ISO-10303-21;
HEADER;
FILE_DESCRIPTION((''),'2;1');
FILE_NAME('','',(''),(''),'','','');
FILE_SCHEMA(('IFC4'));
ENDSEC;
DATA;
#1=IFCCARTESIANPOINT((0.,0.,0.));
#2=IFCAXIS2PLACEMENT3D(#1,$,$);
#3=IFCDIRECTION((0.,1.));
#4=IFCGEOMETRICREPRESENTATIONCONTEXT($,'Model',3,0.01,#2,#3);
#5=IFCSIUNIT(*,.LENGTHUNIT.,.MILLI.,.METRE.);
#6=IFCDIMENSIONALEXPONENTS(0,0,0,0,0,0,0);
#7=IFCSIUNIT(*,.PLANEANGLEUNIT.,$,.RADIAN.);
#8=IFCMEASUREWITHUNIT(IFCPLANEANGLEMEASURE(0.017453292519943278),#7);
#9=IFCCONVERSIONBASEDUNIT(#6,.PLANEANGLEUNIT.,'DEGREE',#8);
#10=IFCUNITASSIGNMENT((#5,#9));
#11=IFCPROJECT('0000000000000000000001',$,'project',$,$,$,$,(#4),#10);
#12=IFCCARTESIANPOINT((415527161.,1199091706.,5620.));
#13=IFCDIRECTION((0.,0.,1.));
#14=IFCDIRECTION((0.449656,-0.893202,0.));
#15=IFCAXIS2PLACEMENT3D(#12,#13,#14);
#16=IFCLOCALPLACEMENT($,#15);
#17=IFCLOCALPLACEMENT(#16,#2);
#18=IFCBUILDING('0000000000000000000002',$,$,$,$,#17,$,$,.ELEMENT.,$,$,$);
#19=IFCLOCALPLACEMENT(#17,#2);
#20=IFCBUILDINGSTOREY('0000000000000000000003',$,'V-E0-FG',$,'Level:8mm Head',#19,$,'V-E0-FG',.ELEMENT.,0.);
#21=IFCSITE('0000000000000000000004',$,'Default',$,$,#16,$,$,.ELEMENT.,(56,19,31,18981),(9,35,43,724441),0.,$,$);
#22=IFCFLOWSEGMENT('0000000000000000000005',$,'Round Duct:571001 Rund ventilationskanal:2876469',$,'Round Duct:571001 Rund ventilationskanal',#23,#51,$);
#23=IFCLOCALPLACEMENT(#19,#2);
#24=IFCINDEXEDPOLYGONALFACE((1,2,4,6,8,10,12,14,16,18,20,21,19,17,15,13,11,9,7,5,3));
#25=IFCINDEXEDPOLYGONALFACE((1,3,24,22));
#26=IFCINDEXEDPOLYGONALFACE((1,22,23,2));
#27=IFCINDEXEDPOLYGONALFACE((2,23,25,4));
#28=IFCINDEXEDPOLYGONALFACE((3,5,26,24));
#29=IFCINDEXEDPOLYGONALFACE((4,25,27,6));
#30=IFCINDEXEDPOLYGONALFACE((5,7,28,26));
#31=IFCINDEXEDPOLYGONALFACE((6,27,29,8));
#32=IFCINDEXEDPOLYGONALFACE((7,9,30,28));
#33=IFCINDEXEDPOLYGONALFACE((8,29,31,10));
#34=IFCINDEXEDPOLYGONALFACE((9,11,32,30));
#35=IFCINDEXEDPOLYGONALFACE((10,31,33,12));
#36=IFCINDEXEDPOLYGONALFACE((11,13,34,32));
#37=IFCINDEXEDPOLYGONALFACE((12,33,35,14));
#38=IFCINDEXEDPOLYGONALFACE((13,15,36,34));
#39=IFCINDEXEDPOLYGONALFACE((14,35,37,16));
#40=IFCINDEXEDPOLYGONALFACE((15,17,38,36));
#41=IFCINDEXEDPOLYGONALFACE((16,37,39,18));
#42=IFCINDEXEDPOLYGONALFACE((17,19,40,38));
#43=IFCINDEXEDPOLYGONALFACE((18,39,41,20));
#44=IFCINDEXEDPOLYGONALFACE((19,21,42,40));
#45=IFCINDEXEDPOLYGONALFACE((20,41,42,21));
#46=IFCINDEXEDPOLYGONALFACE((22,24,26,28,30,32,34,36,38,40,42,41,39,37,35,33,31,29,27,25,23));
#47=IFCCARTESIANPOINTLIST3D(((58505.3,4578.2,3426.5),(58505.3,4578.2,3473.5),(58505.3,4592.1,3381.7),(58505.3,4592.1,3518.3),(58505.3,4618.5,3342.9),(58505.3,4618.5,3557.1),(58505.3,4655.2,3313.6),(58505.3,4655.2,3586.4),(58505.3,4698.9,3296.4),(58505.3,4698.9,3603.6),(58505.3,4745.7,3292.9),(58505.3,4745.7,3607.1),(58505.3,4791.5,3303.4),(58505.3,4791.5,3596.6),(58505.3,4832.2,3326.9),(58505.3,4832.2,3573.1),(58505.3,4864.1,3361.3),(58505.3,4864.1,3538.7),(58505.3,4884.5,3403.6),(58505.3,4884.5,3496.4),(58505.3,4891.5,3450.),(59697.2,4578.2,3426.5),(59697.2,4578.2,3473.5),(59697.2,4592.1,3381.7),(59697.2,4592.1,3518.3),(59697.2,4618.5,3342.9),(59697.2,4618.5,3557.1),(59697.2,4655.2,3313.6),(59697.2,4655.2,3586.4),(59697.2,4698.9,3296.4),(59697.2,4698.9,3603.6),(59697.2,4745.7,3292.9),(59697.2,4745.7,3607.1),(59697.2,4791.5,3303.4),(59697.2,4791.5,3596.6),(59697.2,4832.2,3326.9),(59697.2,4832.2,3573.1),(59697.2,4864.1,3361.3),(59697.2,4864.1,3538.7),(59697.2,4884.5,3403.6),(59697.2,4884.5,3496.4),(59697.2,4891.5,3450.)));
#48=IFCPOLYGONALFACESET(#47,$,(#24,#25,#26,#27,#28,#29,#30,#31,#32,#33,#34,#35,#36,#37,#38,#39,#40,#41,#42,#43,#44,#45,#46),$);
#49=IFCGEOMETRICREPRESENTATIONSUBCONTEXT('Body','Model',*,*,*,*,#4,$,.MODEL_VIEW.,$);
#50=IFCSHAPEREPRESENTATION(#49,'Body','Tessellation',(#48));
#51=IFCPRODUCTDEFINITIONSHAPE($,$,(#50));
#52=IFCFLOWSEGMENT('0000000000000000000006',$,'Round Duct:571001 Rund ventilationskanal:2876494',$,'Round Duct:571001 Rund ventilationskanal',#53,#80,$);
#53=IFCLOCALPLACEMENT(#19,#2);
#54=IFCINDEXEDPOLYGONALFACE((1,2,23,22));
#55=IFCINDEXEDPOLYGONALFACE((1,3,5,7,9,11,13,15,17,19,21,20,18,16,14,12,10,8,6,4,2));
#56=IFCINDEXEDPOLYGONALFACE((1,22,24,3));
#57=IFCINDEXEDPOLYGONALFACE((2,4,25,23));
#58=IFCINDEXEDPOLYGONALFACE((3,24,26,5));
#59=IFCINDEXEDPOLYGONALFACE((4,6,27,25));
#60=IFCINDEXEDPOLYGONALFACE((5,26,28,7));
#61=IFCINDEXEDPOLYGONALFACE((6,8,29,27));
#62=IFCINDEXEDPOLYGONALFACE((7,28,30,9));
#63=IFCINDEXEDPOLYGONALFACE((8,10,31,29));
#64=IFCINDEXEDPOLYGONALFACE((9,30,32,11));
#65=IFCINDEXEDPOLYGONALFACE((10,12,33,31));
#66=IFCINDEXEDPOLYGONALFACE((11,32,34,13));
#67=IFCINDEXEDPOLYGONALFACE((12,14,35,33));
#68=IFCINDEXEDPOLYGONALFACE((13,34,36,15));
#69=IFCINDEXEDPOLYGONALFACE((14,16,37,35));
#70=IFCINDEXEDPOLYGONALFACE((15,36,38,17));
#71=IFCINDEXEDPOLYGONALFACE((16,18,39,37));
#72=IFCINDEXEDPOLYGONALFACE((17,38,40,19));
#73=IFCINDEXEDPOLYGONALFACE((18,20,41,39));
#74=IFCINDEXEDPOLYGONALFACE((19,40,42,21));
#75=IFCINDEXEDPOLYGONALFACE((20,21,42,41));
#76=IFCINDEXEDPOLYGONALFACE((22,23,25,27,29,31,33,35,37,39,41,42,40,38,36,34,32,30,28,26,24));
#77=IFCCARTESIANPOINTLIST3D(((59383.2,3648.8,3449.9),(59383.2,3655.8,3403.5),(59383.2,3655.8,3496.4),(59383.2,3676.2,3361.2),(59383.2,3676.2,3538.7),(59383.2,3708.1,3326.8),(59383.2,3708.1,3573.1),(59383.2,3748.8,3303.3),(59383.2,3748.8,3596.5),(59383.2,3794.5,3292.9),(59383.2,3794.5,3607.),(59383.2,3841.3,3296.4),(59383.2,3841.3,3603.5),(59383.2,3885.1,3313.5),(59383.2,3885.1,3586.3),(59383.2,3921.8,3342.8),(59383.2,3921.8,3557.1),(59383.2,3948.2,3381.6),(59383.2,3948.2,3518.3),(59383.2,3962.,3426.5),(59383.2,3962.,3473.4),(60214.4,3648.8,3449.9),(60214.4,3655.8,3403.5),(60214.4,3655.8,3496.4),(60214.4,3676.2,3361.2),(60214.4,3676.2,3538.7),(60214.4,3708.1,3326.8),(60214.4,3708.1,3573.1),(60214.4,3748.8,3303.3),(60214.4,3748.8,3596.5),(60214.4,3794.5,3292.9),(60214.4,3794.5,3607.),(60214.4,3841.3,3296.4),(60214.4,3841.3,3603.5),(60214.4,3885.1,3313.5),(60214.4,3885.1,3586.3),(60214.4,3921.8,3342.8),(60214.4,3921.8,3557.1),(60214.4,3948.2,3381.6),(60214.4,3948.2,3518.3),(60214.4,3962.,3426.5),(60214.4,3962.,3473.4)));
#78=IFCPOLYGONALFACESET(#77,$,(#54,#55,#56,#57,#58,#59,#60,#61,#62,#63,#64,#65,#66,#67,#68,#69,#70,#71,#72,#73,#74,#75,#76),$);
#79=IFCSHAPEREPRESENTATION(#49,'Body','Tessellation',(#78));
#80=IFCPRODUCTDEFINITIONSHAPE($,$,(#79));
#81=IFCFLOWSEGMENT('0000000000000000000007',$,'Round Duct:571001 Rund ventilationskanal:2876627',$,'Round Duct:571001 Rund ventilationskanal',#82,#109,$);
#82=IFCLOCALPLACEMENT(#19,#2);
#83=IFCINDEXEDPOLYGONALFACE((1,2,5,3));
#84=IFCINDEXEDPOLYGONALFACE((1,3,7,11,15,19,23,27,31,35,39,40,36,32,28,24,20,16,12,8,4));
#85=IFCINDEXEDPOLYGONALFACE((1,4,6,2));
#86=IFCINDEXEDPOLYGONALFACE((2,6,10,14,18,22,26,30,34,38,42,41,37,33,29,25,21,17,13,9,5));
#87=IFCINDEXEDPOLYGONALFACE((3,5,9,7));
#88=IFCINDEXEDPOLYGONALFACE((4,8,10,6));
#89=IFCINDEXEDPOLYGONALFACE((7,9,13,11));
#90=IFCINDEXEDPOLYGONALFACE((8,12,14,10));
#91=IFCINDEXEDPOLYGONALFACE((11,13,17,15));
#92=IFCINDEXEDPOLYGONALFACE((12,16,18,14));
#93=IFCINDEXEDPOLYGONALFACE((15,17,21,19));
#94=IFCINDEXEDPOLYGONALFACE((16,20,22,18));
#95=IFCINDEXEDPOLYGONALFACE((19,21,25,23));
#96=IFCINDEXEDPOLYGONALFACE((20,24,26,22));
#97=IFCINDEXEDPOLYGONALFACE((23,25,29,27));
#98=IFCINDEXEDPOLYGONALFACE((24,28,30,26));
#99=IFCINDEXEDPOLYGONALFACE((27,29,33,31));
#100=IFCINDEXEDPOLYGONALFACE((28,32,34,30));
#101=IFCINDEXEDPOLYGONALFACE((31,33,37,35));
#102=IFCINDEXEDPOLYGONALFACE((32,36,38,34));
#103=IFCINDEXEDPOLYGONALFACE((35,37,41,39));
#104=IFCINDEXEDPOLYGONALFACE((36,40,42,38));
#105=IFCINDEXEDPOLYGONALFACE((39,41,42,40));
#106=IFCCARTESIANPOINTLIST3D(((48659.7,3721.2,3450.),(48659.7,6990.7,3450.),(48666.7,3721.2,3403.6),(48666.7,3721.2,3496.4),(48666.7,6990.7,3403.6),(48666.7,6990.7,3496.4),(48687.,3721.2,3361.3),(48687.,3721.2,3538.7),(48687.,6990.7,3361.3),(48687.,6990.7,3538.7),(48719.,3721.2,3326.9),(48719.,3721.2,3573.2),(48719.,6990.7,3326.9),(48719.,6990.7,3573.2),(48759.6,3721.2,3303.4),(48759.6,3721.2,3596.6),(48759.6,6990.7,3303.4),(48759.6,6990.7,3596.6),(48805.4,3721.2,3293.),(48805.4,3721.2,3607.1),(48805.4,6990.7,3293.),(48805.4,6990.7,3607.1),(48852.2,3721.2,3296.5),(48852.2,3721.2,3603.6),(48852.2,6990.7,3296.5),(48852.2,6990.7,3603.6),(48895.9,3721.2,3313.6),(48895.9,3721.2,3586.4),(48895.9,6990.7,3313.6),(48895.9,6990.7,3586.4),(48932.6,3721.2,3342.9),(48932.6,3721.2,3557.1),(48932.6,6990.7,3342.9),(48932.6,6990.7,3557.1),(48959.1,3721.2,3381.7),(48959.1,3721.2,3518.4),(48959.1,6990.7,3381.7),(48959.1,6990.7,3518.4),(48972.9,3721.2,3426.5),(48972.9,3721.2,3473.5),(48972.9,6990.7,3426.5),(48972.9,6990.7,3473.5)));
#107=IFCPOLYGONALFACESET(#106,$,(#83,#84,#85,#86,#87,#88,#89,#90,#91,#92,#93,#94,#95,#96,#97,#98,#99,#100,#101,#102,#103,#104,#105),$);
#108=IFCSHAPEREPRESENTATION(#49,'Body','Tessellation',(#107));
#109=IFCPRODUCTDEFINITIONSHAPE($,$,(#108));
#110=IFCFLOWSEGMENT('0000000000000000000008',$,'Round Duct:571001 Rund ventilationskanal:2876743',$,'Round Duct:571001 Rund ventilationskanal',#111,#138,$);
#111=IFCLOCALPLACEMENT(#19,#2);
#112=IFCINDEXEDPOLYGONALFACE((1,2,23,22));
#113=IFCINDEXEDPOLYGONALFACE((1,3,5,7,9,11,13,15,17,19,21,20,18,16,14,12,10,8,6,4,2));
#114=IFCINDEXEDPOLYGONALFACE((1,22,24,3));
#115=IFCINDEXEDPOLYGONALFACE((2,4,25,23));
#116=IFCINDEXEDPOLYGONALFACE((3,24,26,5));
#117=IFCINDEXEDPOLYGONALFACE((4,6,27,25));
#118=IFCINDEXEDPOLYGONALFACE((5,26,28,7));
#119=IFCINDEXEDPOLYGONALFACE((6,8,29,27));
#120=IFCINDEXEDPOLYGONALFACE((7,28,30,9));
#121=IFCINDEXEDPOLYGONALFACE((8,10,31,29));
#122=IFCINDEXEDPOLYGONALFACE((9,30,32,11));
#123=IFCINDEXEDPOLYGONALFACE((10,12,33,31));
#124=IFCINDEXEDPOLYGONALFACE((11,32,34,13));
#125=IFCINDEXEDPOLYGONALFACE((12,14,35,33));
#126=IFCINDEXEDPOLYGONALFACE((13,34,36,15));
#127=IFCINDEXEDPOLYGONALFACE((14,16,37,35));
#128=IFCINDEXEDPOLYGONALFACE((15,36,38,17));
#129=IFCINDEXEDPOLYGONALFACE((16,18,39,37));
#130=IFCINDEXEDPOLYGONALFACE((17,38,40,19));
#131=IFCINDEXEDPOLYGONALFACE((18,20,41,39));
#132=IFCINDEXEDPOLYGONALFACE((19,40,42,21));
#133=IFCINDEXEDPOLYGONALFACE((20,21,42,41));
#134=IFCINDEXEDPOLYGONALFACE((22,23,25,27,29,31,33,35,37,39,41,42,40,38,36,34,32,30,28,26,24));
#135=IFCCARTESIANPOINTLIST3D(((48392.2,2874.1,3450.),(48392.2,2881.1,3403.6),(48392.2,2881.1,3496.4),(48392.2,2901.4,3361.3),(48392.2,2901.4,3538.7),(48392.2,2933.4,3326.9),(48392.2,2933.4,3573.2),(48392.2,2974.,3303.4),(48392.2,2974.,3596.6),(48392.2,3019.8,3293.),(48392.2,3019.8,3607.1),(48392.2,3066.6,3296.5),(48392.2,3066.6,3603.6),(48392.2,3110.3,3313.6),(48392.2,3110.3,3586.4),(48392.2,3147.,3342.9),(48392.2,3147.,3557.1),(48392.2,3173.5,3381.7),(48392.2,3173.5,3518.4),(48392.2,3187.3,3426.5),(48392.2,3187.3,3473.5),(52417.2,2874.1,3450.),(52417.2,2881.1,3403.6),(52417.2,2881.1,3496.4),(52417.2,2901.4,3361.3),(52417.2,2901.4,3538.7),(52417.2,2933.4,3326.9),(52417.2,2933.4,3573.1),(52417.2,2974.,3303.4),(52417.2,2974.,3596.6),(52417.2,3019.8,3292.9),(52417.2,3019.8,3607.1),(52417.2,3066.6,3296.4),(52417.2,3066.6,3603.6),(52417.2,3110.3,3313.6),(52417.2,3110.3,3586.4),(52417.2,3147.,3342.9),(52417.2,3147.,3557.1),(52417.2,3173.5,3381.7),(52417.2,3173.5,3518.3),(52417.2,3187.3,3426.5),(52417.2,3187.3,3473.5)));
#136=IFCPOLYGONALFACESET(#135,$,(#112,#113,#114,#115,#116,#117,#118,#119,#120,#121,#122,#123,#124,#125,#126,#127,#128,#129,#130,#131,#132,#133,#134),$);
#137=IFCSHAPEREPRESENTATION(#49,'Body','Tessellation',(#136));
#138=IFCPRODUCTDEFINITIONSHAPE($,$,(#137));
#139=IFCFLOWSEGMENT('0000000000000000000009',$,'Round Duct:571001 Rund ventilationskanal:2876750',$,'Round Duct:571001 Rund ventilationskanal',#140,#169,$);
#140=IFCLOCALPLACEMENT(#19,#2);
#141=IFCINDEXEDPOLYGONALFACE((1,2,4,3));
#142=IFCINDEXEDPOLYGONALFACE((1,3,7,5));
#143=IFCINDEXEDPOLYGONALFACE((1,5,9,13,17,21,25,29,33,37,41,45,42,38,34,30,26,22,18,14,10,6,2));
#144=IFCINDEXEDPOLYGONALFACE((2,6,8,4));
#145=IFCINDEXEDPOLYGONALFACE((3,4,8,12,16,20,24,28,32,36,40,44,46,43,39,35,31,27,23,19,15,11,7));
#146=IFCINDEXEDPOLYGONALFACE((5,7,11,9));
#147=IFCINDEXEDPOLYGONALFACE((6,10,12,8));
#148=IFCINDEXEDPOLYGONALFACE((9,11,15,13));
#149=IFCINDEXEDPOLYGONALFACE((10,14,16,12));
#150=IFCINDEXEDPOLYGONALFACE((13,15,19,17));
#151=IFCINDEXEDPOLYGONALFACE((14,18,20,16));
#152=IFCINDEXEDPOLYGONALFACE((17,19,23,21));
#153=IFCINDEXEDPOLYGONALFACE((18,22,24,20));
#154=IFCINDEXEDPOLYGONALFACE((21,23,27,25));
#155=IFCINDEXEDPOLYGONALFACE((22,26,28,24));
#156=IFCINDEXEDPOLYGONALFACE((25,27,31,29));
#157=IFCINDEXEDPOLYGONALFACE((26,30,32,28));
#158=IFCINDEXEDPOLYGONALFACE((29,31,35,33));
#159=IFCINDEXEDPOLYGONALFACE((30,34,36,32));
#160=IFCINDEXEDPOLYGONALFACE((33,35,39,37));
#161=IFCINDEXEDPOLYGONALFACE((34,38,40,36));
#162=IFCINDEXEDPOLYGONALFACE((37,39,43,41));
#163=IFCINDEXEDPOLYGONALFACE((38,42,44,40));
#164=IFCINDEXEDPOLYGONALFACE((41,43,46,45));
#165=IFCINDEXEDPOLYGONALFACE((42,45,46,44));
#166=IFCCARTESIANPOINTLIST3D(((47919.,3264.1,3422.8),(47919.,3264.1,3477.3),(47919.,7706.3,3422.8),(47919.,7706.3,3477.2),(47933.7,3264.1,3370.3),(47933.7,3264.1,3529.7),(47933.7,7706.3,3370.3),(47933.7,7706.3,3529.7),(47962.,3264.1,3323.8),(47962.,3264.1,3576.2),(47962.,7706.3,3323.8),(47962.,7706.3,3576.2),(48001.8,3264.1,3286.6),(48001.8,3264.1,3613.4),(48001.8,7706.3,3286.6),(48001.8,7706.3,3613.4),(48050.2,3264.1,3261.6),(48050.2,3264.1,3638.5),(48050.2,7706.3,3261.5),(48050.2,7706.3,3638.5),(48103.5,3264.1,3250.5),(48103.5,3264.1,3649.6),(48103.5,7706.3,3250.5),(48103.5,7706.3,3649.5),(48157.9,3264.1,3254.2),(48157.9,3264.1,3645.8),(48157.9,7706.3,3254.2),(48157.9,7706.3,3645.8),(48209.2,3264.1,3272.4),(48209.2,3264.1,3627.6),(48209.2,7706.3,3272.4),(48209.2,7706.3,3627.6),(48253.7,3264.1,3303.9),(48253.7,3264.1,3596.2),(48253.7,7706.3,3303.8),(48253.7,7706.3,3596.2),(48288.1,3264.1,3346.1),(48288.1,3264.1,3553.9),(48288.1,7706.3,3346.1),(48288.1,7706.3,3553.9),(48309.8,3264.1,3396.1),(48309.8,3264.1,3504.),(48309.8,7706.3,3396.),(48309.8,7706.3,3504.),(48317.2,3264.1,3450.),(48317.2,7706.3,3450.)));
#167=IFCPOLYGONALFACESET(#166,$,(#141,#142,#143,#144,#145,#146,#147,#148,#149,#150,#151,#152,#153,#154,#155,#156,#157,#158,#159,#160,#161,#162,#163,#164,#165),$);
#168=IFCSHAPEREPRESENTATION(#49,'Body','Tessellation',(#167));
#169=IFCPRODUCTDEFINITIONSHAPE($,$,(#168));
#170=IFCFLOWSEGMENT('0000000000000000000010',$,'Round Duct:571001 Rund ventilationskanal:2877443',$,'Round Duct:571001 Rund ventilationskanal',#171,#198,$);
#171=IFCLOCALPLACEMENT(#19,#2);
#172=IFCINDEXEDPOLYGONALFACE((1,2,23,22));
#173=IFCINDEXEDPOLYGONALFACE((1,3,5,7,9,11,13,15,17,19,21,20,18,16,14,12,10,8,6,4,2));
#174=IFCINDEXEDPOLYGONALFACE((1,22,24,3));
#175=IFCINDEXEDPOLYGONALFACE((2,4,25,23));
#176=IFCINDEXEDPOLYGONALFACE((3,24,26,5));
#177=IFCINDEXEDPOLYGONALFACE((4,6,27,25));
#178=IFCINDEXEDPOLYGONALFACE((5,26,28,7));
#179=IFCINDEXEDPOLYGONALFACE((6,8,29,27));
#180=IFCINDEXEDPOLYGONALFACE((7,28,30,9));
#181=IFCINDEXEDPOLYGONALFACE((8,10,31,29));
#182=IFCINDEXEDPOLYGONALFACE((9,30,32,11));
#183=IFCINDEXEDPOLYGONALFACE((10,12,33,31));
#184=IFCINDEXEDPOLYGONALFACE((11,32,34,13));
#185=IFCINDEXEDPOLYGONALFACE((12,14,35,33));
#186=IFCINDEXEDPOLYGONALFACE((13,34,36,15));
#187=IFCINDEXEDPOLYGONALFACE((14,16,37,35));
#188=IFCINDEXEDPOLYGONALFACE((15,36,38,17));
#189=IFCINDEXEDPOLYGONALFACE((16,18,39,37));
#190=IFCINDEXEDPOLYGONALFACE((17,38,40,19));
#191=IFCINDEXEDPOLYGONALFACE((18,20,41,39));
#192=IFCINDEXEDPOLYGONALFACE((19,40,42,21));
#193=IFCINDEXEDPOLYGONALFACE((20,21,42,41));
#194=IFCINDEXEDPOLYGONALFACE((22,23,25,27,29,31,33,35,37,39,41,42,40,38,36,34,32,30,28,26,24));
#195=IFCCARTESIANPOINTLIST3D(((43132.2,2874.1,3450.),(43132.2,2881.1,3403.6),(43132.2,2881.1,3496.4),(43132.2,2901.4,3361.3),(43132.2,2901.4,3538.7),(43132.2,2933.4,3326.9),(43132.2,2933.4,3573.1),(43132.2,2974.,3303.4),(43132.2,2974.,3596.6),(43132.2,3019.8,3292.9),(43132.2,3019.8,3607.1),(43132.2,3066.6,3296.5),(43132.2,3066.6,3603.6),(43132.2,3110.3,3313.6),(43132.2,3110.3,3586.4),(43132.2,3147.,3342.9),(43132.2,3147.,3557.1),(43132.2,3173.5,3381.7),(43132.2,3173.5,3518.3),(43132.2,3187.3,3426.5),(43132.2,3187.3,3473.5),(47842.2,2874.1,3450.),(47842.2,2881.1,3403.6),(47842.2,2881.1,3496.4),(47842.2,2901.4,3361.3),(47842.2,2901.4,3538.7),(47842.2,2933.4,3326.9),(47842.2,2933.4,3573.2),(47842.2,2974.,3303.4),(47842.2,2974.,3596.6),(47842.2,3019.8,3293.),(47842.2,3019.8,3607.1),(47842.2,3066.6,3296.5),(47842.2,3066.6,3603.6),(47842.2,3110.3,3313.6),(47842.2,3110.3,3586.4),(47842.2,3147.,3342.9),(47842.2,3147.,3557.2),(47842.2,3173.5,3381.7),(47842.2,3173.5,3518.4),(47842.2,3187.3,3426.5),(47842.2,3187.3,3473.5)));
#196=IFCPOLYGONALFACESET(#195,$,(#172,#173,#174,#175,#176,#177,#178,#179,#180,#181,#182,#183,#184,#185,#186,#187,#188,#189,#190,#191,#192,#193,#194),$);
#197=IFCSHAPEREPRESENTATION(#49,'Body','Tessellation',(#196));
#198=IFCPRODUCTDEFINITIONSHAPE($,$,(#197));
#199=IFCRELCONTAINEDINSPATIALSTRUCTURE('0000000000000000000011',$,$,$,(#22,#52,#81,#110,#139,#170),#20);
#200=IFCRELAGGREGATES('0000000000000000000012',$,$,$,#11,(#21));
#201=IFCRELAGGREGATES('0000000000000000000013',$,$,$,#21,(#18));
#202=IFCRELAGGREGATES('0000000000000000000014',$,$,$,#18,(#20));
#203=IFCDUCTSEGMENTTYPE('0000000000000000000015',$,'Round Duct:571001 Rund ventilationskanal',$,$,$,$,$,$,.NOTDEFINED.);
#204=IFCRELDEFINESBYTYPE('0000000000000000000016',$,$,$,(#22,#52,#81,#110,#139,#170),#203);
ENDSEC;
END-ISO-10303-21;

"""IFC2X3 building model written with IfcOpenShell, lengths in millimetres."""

from ifc_helpers import new_model, entity, si_unit, converted_unit, direction, frame, frame_2d, origin, origin_2d_with_axis, place, context, subcontext, project, spatial, circle, extrude, type_object, element, save


model = new_model("IFC2X3")

# Units and contexts
model_context = context("Model", 3, precision=0.01, world=origin(), true_north=direction((0.0, 1.0)))
body_context = subcontext(model_context, "Body", "Model", "MODEL_VIEW")
ifc_project = project(units=[si_unit("LENGTHUNIT", "METRE", prefix="MILLI"), converted_unit("PLANEANGLEUNIT", "DEGREE", entity("IfcPlaneAngleMeasure", 0.017453292519943278), si_unit("PLANEANGLEUNIT", "RADIAN"), dimensions=[0, 0, 0, 0, 0, 0, 0])], contexts=[model_context])

# Site, building, storey
site_placement = place(None, frame((415527161.0, 1199091706.0, 5620.0), z_axis=(0.0, 0.0, 1.0), x_axis=(0.449656, -0.893202, 0.0)))
site = spatial("IfcSite", under=ifc_project, at=site_placement, Name="Default", CompositionType="ELEMENT", RefLatitude=(56, 19, 31, 18981), RefLongitude=(9, 35, 43, 724441), RefElevation=0.0)
building_placement = place(site_placement, origin())
building = spatial("IfcBuilding", under=site, at=building_placement, CompositionType="ELEMENT")
storey_placement = place(building_placement, origin())
storey = spatial("IfcBuildingStorey", under=building, at=storey_placement, Name="V-E0-FG", ObjectType="Level:8mm Head", LongName="V-E0-FG", CompositionType="ELEMENT", Elevation=0.0)

# Flow segments
duct_segment_type = type_object("IfcDuctSegmentType", Name="Round Duct:571001 Rund ventilationskanal", PredefinedType="NOTDEFINED")
flow_segment_1_placement = place(storey_placement, origin())
element("IfcFlowSegment", 1, at=flow_segment_1_placement, inside=storey, type_object=duct_segment_type, Name="Round Duct:571001 Rund ventilationskanal:2876469", ObjectType="Round Duct:571001 Rund ventilationskanal", context=body_context, shape_type="SweptSolid", body=[
    extrude(circle(Radius=157.5, at=frame_2d((0.0, 0.0), x_axis=(1.0, 0.0))), frame((58505.3, 4734.0, 3450.0), z_axis=(1.0, 0.0, 0.0), x_axis=(0.0, 1.0, 0.0)), (0.0, 0.0, 1.0), 1191.9),
])
flow_segment_2_placement = place(storey_placement, origin())
element("IfcFlowSegment", 2, at=flow_segment_2_placement, inside=storey, type_object=duct_segment_type, Name="Round Duct:571001 Rund ventilationskanal:2876494", ObjectType="Round Duct:571001 Rund ventilationskanal", context=body_context, shape_type="SweptSolid", body=[
    extrude(circle(Radius=157.5, at=origin_2d_with_axis()), frame((59383.2, 3806.3, 3449.9), z_axis=(1.0, 0.0, 0.0), x_axis=(0.0, -1.0, 0.0)), (0.0, 0.0, 1.0), 831.2),
])
flow_segment_3_placement = place(storey_placement, origin())
element("IfcFlowSegment", 3, at=flow_segment_3_placement, inside=storey, type_object=duct_segment_type, Name="Round Duct:571001 Rund ventilationskanal:2876627", ObjectType="Round Duct:571001 Rund ventilationskanal", context=body_context, shape_type="SweptSolid", body=[
    extrude(circle(Radius=157.5, at=frame_2d((0.0, 0.0), x_axis=(1.0, 0.0))), frame((48817.2, 3721.2, 3450.0), z_axis=(0.0, 1.0, 0.0), x_axis=(-1.0, 0.0, 0.0)), (0.0, 0.0, 1.0), 3269.5),
])
flow_segment_4_placement = place(storey_placement, origin())
element("IfcFlowSegment", 4, at=flow_segment_4_placement, inside=storey, type_object=duct_segment_type, Name="Round Duct:571001 Rund ventilationskanal:2876743", ObjectType="Round Duct:571001 Rund ventilationskanal", context=body_context, shape_type="SweptSolid", body=[
    extrude(circle(Radius=157.5, at=frame_2d((0.0, 0.0), x_axis=(1.0, 0.0))), frame((48392.2, 3031.6, 3450.0), z_axis=(1.0, 0.0, -0.000005), x_axis=(0.0, -1.0, 0.0)), (0.0, 0.0, 1.0), 4025.0),
])
flow_segment_5_placement = place(storey_placement, origin())
element("IfcFlowSegment", 5, at=flow_segment_5_placement, inside=storey, type_object=duct_segment_type, Name="Round Duct:571001 Rund ventilationskanal:2876750", ObjectType="Round Duct:571001 Rund ventilationskanal", context=body_context, shape_type="SweptSolid", body=[
    extrude(circle(Radius=200.0, at=frame_2d((0.0, 0.0), x_axis=(1.0, 0.0))), frame((48117.2, 3264.1, 3450.0), z_axis=(0.0, 1.0, -0.000004), x_axis=(1.0, 0.0, 0.0)), (0.0, 0.0, 1.0), 4442.2),
])
flow_segment_6_placement = place(storey_placement, origin())
element("IfcFlowSegment", 6, at=flow_segment_6_placement, inside=storey, type_object=duct_segment_type, Name="Round Duct:571001 Rund ventilationskanal:2877443", ObjectType="Round Duct:571001 Rund ventilationskanal", context=body_context, shape_type="SweptSolid", body=[
    extrude(circle(Radius=157.5, at=frame_2d((0.0, 0.0), x_axis=(1.0, 0.0))), frame((43132.2, 3031.6, 3450.0), z_axis=(1.0, 0.0, 0.000005), x_axis=(0.0, -1.0, 0.0)), (0.0, 0.0, 1.0), 4710.0),
])

save(model, "model.ifc")
